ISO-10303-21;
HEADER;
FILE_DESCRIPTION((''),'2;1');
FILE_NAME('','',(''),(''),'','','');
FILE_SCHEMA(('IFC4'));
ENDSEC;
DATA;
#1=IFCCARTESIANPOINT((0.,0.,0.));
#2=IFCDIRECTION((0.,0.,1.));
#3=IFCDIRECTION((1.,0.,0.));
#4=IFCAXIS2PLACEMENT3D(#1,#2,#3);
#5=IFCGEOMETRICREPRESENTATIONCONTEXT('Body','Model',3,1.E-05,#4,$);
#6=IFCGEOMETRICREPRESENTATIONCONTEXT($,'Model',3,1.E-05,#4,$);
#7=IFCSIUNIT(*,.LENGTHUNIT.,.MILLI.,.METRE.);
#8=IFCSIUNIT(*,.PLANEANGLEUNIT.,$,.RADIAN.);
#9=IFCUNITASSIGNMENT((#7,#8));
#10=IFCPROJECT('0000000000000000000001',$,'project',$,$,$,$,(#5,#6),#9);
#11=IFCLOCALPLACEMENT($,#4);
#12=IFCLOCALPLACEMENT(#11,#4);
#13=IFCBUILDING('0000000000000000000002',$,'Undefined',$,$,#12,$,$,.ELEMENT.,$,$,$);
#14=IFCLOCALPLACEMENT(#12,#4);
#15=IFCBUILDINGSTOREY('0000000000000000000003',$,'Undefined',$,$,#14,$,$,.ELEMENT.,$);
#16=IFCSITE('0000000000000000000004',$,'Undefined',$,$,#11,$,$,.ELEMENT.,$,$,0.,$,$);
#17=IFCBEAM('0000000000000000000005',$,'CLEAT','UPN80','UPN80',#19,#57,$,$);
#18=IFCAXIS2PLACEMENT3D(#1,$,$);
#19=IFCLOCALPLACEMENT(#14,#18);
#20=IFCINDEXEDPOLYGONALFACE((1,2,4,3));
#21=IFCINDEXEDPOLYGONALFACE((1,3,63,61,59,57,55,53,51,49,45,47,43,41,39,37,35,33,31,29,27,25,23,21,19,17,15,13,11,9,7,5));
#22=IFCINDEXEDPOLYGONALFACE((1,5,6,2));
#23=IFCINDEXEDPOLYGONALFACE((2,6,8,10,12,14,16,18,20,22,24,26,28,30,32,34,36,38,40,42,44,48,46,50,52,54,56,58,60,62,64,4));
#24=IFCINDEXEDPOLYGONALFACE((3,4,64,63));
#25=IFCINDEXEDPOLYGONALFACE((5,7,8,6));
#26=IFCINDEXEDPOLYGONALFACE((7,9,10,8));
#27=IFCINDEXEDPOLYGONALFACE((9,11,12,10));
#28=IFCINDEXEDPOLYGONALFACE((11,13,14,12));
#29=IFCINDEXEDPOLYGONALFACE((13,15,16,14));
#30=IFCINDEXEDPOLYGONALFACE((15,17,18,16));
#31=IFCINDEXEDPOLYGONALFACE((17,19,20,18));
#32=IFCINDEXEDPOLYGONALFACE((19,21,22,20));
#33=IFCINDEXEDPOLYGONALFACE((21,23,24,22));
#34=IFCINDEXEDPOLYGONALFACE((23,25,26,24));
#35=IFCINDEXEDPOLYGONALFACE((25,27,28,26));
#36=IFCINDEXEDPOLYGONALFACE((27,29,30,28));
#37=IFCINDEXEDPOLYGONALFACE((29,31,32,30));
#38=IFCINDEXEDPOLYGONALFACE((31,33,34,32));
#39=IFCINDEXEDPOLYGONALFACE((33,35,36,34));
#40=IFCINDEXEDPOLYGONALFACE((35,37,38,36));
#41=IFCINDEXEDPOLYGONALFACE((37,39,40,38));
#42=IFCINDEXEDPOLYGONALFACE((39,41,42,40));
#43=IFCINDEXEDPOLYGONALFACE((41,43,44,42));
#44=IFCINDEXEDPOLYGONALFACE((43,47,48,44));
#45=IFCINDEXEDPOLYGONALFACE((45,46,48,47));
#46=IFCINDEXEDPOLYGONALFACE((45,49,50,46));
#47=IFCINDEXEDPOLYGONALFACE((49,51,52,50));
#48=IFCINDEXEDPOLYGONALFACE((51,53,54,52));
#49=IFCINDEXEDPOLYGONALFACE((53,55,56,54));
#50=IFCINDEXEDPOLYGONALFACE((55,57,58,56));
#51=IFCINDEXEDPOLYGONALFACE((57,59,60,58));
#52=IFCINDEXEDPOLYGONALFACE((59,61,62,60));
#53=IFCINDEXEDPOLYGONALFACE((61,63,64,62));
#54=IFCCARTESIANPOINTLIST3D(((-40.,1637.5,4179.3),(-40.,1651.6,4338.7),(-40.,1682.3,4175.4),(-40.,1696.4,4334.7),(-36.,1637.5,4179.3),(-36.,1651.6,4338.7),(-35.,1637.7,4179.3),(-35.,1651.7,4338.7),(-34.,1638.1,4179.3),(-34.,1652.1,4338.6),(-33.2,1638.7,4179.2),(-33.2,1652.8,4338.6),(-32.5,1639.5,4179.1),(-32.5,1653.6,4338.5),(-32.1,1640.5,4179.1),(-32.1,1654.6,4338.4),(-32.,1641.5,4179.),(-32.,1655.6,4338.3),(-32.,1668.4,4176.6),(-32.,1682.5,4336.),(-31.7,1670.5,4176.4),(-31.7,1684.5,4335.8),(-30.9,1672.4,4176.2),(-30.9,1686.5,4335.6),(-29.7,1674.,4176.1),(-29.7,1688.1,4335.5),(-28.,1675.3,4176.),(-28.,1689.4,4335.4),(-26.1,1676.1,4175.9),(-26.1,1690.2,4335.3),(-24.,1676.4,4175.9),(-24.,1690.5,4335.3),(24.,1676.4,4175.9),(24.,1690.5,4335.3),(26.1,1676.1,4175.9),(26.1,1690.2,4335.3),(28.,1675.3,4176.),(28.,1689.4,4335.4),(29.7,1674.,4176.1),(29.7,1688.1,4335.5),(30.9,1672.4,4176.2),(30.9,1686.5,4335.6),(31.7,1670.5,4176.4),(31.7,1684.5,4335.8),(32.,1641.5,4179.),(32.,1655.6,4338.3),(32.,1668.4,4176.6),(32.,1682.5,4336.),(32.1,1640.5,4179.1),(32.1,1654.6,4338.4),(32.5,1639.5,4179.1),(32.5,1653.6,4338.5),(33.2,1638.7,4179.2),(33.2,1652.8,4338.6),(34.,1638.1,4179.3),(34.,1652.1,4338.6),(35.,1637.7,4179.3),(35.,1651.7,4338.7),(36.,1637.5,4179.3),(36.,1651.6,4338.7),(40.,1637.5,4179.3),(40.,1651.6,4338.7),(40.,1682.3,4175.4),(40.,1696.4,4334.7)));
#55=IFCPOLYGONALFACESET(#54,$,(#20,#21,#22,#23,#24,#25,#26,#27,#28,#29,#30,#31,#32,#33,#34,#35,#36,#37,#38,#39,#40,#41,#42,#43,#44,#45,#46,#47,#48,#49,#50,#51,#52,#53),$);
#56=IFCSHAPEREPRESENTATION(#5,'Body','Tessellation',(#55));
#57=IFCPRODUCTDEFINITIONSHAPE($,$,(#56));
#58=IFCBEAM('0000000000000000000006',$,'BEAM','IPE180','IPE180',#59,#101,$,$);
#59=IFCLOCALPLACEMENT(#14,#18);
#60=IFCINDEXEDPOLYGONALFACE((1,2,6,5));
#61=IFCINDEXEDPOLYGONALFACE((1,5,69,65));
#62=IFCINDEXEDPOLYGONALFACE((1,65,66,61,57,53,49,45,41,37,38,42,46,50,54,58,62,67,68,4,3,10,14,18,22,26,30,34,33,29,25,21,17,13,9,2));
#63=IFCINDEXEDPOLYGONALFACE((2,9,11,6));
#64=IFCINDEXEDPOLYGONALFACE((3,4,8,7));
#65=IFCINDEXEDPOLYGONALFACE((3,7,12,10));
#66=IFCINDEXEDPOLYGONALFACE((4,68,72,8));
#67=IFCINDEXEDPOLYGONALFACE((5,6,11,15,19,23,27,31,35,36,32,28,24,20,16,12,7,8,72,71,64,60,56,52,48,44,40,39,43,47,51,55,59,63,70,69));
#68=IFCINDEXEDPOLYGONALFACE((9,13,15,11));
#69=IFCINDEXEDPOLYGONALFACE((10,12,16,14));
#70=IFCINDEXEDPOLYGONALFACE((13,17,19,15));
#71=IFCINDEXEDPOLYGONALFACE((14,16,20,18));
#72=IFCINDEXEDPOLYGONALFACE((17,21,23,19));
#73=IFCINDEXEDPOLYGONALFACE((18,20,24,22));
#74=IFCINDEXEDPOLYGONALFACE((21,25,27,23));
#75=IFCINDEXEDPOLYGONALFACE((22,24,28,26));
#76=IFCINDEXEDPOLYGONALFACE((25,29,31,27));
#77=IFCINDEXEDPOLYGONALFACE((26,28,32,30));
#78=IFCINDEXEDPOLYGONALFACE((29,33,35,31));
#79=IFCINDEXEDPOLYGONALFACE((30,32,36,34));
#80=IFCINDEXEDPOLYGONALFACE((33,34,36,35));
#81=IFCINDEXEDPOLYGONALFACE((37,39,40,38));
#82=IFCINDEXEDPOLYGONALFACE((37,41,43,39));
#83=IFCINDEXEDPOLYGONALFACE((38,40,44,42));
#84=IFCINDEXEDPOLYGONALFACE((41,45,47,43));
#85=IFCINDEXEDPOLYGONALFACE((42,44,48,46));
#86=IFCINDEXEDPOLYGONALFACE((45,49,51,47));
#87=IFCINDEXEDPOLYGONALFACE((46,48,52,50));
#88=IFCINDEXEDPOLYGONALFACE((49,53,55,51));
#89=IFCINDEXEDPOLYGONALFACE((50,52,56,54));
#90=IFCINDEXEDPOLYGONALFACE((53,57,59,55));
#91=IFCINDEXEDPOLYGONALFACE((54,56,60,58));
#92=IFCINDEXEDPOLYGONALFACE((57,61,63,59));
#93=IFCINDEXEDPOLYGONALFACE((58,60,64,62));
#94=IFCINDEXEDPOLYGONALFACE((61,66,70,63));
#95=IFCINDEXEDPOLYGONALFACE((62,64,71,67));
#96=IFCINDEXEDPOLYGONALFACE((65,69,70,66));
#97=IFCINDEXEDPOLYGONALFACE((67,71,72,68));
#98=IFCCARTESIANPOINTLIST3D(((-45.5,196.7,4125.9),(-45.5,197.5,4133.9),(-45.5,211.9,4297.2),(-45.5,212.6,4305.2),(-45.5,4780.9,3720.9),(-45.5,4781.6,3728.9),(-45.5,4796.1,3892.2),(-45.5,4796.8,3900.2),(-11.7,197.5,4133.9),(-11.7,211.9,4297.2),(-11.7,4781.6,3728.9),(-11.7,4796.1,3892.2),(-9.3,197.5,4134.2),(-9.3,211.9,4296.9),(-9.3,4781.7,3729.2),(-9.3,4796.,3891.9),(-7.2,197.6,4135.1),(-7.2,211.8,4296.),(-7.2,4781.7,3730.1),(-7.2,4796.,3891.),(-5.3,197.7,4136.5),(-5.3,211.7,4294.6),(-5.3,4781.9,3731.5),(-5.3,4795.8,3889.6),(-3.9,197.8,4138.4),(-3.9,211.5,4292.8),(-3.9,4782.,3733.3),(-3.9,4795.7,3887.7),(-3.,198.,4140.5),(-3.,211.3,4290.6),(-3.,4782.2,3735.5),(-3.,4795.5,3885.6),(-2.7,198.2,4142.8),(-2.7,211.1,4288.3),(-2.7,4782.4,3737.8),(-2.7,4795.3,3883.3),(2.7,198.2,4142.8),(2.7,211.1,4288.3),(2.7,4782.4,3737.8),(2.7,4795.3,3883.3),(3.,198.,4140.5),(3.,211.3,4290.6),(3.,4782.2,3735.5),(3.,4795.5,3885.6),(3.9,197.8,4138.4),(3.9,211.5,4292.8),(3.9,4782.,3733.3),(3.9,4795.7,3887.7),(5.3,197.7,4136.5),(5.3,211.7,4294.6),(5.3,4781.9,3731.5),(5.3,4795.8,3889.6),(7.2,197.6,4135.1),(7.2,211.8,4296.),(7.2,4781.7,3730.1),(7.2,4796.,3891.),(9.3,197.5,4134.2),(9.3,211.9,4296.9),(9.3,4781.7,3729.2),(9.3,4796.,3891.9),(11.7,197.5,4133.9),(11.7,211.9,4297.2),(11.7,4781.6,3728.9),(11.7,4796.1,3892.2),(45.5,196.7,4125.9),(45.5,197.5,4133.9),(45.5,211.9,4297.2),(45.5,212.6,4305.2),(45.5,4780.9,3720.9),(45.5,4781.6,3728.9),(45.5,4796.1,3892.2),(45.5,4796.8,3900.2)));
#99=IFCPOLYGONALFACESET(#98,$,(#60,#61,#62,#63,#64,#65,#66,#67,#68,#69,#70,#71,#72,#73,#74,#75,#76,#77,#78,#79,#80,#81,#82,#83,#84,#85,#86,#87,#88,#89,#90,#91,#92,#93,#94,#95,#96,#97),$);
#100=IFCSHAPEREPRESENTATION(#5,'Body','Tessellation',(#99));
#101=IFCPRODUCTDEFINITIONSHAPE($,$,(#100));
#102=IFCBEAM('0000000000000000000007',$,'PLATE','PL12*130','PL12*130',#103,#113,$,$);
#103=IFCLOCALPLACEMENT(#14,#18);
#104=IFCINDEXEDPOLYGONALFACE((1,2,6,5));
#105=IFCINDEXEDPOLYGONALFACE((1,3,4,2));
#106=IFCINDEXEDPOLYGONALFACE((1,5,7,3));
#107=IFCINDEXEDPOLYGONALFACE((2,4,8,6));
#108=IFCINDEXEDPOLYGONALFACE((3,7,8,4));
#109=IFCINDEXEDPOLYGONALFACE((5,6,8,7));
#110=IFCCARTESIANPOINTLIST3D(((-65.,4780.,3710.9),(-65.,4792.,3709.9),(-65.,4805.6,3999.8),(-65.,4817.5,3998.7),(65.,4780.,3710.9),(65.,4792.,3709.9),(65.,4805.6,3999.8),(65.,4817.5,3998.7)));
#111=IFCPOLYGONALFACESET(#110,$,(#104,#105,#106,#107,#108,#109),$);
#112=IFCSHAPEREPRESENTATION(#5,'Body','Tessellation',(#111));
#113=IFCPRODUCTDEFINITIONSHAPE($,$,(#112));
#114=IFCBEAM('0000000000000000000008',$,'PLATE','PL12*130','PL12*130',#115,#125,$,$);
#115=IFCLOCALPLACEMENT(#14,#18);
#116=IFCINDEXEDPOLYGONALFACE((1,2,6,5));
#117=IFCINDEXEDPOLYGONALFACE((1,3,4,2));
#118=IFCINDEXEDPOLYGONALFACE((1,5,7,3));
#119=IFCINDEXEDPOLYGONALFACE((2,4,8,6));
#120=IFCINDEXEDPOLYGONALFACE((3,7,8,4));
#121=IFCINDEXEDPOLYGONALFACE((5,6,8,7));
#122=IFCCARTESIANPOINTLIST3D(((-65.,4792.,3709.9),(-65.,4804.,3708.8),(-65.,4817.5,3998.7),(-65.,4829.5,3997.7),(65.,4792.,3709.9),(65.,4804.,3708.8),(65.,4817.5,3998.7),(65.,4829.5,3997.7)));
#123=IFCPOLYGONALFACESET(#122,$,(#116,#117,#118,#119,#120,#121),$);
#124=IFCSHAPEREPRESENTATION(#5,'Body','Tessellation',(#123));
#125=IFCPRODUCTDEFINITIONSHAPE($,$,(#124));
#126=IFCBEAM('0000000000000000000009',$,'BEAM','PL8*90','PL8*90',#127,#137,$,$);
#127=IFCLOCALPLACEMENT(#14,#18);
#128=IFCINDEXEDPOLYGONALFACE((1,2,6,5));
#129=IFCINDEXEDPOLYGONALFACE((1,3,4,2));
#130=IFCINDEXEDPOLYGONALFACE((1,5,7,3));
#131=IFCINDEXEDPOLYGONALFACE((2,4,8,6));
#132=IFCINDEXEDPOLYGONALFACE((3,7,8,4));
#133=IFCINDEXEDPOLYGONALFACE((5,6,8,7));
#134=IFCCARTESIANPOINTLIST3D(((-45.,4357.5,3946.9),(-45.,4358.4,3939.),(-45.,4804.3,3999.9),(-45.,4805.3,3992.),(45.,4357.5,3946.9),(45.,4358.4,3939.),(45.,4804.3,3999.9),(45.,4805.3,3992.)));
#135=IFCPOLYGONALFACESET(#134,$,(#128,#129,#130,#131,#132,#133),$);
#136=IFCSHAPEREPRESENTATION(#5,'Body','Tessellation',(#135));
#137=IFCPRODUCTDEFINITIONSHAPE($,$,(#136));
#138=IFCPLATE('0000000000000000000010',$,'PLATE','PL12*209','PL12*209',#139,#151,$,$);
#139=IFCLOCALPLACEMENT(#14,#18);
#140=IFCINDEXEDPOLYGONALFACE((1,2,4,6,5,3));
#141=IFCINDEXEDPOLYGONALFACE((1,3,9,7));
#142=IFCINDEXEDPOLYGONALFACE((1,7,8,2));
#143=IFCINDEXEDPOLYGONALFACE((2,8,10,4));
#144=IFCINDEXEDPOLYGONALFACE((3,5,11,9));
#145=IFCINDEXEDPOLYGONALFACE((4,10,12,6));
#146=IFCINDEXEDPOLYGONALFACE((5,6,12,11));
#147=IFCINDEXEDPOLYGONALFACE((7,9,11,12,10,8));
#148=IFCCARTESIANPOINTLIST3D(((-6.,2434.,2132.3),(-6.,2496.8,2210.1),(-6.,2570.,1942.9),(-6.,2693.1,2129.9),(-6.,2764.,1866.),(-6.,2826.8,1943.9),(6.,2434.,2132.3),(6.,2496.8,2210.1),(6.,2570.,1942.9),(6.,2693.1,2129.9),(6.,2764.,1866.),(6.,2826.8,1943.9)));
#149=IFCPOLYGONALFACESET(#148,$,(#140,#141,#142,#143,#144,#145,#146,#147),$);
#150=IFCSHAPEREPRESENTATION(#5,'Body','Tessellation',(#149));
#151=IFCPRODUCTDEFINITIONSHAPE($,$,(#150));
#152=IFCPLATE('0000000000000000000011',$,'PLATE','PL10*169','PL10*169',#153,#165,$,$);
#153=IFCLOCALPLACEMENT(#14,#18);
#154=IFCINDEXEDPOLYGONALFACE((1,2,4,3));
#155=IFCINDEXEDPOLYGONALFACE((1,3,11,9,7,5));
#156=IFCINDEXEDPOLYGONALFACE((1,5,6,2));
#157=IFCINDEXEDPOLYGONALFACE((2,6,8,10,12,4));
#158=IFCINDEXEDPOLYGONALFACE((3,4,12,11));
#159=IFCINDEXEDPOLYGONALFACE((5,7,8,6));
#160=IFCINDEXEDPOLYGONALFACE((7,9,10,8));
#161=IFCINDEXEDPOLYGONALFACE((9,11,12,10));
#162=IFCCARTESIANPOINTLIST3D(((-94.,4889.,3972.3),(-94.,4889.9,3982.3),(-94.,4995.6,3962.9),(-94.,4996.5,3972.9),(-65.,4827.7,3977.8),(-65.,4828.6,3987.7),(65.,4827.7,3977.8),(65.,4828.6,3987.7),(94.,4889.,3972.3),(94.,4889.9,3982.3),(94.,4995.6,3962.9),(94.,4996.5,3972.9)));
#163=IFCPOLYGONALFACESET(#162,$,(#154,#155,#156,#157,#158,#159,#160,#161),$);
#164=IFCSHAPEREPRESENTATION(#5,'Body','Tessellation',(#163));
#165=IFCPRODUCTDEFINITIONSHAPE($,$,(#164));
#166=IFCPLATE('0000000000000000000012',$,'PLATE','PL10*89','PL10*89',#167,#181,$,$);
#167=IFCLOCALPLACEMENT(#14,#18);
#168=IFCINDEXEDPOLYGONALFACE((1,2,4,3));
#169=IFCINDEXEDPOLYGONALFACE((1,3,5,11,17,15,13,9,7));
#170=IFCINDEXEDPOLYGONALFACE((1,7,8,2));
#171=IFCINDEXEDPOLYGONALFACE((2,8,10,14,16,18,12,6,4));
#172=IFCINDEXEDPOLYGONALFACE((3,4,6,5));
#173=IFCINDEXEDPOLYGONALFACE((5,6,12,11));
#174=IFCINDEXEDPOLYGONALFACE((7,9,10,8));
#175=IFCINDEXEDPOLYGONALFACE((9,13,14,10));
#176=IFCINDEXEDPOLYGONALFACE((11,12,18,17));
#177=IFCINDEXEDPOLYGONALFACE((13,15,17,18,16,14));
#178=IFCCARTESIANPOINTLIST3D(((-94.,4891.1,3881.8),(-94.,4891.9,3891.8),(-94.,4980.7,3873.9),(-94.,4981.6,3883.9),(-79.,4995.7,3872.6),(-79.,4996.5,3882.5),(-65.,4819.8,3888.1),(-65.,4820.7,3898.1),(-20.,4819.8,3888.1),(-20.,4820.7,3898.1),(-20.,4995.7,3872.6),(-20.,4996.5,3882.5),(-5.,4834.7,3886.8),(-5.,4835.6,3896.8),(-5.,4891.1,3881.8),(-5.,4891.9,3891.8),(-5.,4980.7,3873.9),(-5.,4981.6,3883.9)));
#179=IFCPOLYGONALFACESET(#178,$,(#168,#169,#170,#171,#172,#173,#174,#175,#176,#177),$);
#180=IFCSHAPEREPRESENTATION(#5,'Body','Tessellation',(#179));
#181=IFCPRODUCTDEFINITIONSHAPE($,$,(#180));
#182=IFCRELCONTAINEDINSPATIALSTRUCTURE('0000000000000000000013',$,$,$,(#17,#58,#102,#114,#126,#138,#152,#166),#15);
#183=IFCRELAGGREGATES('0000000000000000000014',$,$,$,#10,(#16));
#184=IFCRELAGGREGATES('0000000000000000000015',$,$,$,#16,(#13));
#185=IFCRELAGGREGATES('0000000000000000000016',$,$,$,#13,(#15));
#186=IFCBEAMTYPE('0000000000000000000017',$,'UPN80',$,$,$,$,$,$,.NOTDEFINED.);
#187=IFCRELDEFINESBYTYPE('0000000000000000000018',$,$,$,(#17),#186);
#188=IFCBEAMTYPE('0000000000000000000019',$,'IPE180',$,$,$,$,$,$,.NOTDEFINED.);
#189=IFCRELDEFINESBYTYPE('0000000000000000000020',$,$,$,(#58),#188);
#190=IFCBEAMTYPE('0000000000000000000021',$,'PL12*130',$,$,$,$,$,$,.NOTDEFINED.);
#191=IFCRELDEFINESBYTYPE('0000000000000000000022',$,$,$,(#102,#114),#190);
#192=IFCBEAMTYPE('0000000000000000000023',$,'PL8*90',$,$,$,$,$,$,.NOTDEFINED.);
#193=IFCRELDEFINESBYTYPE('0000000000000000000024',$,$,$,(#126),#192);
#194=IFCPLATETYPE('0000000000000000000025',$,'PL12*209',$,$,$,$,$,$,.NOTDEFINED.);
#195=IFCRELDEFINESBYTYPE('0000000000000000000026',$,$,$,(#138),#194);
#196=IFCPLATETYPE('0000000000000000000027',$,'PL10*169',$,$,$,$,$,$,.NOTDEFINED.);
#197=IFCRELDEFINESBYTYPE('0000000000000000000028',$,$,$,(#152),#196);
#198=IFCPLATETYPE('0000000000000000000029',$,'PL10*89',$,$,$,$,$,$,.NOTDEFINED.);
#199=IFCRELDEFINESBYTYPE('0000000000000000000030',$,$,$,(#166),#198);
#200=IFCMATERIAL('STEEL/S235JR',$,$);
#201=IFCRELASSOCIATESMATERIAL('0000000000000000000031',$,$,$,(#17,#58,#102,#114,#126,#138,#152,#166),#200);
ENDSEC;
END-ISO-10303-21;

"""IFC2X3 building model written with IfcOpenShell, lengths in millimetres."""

from ifc_helpers import new_model, si_unit, frame, origin_with_axes, origin_2d_with_axis, place, context, project, spatial, polyline, rectangle, i_section, u_section, outline, extrude, material, type_object, element, save


model = new_model("IFC2X3")

# Units and contexts
model_context_1 = context("Model", 3, precision=1e-05, world=origin_with_axes(), identifier="Body")
model_context_2 = context("Model", 3, precision=1e-05, world=origin_with_axes())
ifc_project = project(units=[si_unit("LENGTHUNIT", "METRE", prefix="MILLI"), si_unit("PLANEANGLEUNIT", "RADIAN")], contexts=[model_context_1, model_context_2])

# Site, building, storey
site_placement = place(None, origin_with_axes())
site = spatial("IfcSite", under=ifc_project, at=site_placement, Name="Undefined", CompositionType="ELEMENT", RefElevation=0.0)
building_placement = place(site_placement, origin_with_axes())
building = spatial("IfcBuilding", under=site, at=building_placement, Name="Undefined", CompositionType="ELEMENT")
storey_placement = place(building_placement, origin_with_axes())
storey = spatial("IfcBuildingStorey", under=building, at=storey_placement, Name="Undefined", CompositionType="ELEMENT")

# Shared definitions
ifc_material = material(Name="STEEL/S235JR")

# Beams
beam_type_1 = type_object("IfcBeamType", Name="UPN80", PredefinedType="NOTDEFINED")
for number, where, z_axis, x_axis, name in (
    (1, (0.0, 1659.9, 4177.3), (-1.0, 0.0, 0.0), (0.0, 0.08801, 0.99612), "CLEAT"),
):
    element("IfcBeam", number, at=place(storey_placement, frame(where, z_axis=z_axis, x_axis=x_axis)), inside=storey, type_object=beam_type_1, material=ifc_material, Name=name, Description="UPN80", ObjectType="UPN80", context=model_context_1, shape_type="SweptSolid", body=[
        extrude(u_section(Depth=80.0, FlangeWidth=45.0, WebThickness=6.0, FlangeThickness=8.0, FilletRadius=8.0, EdgeRadius=4.0, at=origin_2d_with_axis()), frame((160.0, 0.0, 0.0), z_axis=(-1.0, 0.0, 0.0), x_axis=(0.0, -1.0, 0.0)), (0.0, 0.0, 1.0), 160.0),
    ])
beam_type_2 = type_object("IfcBeamType", Name="IPE180", PredefinedType="NOTDEFINED")
beam_1_placement = place(storey_placement, frame((0.0, 4788.8, 3810.5), z_axis=(0.0, 0.08801, 0.99612), x_axis=(0.0, -0.99612, 0.08801)))
element("IfcBeam", 2, at=beam_1_placement, inside=storey, type_object=beam_type_2, material=ifc_material, Name="BEAM", Description="IPE180", ObjectType="IPE180", context=model_context_1, shape_type="SweptSolid", body=[
    extrude(i_section(OverallWidth=91.0, OverallDepth=180.0, WebThickness=5.3, FlangeThickness=8.0, FilletRadius=9.0, at=origin_2d_with_axis()), frame((4602.0, 0.0, 0.0), z_axis=(-1.0, 0.0, 0.0), x_axis=(0.0, -1.0, 0.0)), (0.0, 0.0, 1.0), 4602.0),
])
beam_type_3 = type_object("IfcBeamType", Name="PL12*130", PredefinedType="NOTDEFINED")
beam_2_placement = place(storey_placement, frame((0.0, 4786.0, 3710.4), z_axis=(-1.0, 0.0, 0.0), x_axis=(0.0, 0.087999, 0.996121)))
element("IfcBeam", 3, at=beam_2_placement, inside=storey, type_object=beam_type_3, material=ifc_material, Name="PLATE", Description="PL12*130", ObjectType="PL12*130", context=model_context_1, shape_type="SweptSolid", body=[
    extrude(rectangle(XDim=12.0, YDim=130.0, at=origin_2d_with_axis()), frame((290.0, 0.0, 0.0), z_axis=(-1.0, 0.0, 0.0), x_axis=(0.0, -1.0, 0.0)), (0.0, 0.0, 1.0), 290.0),
])
beam_3_placement = place(storey_placement, frame((0.0, 4798.0, 3709.3), z_axis=(-1.0, 0.0, 0.0), x_axis=(0.0, 0.087999, 0.996121)))
element("IfcBeam", 4, at=beam_3_placement, inside=storey, type_object=beam_type_3, material=ifc_material, Name="PLATE", Description="PL12*130", ObjectType="PL12*130", context=model_context_1, shape_type="SweptSolid", body=[
    extrude(rectangle(XDim=12.0, YDim=130.0, at=origin_2d_with_axis()), frame((290.0, 0.0, 0.0), z_axis=(-1.0, 0.0, 0.0), x_axis=(0.0, -1.0, 0.0)), (0.0, 0.0, 1.0), 290.0),
])
beam_type_4 = type_object("IfcBeamType", Name="PL8*90", PredefinedType="NOTDEFINED")
beam_4_placement = place(storey_placement, frame((0.0, 4804.8, 3995.9), z_axis=(-1.0, 0.0, 0.0), x_axis=(0.0, -0.993046, -0.117724)))
element("IfcBeam", 5, at=beam_4_placement, inside=storey, type_object=beam_type_4, material=ifc_material, Name="BEAM", Description="PL8*90", ObjectType="PL8*90", context=model_context_1, shape_type="SweptSolid", body=[
    extrude(rectangle(XDim=8.0, YDim=90.0, at=origin_2d_with_axis()), frame((450.0, 0.0, 0.0), z_axis=(-1.0, 0.0, 0.0), x_axis=(0.0, -1.0, 0.0)), (0.0, 0.0, 1.0), 450.0),
])

# Plates
plate_type_1 = type_object("IfcPlateType", Name="PL12*209", PredefinedType="NOTDEFINED")
plate_1_placement = place(storey_placement, frame((0.0, 2826.8, 1943.9), z_axis=(1.0, 0.0, 0.0), x_axis=(0.0, -0.583503, 0.812111)))
element("IfcPlate", 6, at=plate_1_placement, inside=storey, type_object=plate_type_1, material=ifc_material, Name="PLATE", Description="PL12*209", ObjectType="PL12*209", context=model_context_1, shape_type="SweptSolid", body=[
    extrude(outline(polyline([(0.0, 0.0), (229.0, 0.0), (408.7, 112.6), (382.2, 209.1), (149.0, 209.1), (-26.6, 96.4), (0.0, 0.0)])), frame((0.0, 0.0, -6.0), z_axis=(0.0, 0.0, 1.0), x_axis=(1.0, 0.0, 0.0)), (0.0, 0.0, 1.0), 12.0),
])
plate_type_2 = type_object("IfcPlateType", Name="PL10*169", PredefinedType="NOTDEFINED")
plate_2_placement = place(storey_placement, frame((65.0, 4828.2, 3982.7), z_axis=(0.0, 0.08801, 0.99612), x_axis=(0.426221, 0.901109, -0.079616)))
element("IfcPlate", 7, at=plate_2_placement, inside=storey, type_object=plate_type_2, material=ifc_material, Name="PLATE", Description="PL10*169", ObjectType="PL10*169", context=model_context_1, shape_type="SweptSolid", body=[
    extrude(outline(polyline([(0.0, 0.0), (68.0, 0.0), (164.8, 45.6), (84.7, 215.7), (-12.1, 170.1), (-55.4, 117.6), (0.0, 0.0)])), frame((0.0, 0.0, -5.0), z_axis=(0.0, 0.0, 1.0), x_axis=(1.0, 0.0, 0.0)), (0.0, 0.0, 1.0), 10.0),
])
plate_type_3 = type_object("IfcPlateType", Name="PL10*89", PredefinedType="NOTDEFINED")
for number, where, z_axis, x_axis, name in (
    (8, (-5.0, 4820.2, 3893.1), (0.0, 0.08801, 0.99612), (0.0, 0.99612, -0.08801), "PLATE"),
):
    element("IfcPlate", number, at=place(storey_placement, frame(where, z_axis=z_axis, x_axis=x_axis)), inside=storey, type_object=plate_type_3, material=ifc_material, Name=name, Description="PL10*89", ObjectType="PL10*89", context=model_context_1, shape_type="SweptSolid", body=[
        extrude(outline(polyline([(0.0, 15.0), (15.0, 0.0), (71.6, 0.0), (161.6, 0.0), (176.6, 15.0), (176.6, 74.0), (161.6, 89.0), (71.6, 89.0), (0.0, 60.0), (0.0, 15.0)])), frame((0.0, 0.0, -5.0), z_axis=(0.0, 0.0, 1.0), x_axis=(1.0, 0.0, 0.0)), (0.0, 0.0, 1.0), 10.0),
    ])

save(model, "model.ifc")
